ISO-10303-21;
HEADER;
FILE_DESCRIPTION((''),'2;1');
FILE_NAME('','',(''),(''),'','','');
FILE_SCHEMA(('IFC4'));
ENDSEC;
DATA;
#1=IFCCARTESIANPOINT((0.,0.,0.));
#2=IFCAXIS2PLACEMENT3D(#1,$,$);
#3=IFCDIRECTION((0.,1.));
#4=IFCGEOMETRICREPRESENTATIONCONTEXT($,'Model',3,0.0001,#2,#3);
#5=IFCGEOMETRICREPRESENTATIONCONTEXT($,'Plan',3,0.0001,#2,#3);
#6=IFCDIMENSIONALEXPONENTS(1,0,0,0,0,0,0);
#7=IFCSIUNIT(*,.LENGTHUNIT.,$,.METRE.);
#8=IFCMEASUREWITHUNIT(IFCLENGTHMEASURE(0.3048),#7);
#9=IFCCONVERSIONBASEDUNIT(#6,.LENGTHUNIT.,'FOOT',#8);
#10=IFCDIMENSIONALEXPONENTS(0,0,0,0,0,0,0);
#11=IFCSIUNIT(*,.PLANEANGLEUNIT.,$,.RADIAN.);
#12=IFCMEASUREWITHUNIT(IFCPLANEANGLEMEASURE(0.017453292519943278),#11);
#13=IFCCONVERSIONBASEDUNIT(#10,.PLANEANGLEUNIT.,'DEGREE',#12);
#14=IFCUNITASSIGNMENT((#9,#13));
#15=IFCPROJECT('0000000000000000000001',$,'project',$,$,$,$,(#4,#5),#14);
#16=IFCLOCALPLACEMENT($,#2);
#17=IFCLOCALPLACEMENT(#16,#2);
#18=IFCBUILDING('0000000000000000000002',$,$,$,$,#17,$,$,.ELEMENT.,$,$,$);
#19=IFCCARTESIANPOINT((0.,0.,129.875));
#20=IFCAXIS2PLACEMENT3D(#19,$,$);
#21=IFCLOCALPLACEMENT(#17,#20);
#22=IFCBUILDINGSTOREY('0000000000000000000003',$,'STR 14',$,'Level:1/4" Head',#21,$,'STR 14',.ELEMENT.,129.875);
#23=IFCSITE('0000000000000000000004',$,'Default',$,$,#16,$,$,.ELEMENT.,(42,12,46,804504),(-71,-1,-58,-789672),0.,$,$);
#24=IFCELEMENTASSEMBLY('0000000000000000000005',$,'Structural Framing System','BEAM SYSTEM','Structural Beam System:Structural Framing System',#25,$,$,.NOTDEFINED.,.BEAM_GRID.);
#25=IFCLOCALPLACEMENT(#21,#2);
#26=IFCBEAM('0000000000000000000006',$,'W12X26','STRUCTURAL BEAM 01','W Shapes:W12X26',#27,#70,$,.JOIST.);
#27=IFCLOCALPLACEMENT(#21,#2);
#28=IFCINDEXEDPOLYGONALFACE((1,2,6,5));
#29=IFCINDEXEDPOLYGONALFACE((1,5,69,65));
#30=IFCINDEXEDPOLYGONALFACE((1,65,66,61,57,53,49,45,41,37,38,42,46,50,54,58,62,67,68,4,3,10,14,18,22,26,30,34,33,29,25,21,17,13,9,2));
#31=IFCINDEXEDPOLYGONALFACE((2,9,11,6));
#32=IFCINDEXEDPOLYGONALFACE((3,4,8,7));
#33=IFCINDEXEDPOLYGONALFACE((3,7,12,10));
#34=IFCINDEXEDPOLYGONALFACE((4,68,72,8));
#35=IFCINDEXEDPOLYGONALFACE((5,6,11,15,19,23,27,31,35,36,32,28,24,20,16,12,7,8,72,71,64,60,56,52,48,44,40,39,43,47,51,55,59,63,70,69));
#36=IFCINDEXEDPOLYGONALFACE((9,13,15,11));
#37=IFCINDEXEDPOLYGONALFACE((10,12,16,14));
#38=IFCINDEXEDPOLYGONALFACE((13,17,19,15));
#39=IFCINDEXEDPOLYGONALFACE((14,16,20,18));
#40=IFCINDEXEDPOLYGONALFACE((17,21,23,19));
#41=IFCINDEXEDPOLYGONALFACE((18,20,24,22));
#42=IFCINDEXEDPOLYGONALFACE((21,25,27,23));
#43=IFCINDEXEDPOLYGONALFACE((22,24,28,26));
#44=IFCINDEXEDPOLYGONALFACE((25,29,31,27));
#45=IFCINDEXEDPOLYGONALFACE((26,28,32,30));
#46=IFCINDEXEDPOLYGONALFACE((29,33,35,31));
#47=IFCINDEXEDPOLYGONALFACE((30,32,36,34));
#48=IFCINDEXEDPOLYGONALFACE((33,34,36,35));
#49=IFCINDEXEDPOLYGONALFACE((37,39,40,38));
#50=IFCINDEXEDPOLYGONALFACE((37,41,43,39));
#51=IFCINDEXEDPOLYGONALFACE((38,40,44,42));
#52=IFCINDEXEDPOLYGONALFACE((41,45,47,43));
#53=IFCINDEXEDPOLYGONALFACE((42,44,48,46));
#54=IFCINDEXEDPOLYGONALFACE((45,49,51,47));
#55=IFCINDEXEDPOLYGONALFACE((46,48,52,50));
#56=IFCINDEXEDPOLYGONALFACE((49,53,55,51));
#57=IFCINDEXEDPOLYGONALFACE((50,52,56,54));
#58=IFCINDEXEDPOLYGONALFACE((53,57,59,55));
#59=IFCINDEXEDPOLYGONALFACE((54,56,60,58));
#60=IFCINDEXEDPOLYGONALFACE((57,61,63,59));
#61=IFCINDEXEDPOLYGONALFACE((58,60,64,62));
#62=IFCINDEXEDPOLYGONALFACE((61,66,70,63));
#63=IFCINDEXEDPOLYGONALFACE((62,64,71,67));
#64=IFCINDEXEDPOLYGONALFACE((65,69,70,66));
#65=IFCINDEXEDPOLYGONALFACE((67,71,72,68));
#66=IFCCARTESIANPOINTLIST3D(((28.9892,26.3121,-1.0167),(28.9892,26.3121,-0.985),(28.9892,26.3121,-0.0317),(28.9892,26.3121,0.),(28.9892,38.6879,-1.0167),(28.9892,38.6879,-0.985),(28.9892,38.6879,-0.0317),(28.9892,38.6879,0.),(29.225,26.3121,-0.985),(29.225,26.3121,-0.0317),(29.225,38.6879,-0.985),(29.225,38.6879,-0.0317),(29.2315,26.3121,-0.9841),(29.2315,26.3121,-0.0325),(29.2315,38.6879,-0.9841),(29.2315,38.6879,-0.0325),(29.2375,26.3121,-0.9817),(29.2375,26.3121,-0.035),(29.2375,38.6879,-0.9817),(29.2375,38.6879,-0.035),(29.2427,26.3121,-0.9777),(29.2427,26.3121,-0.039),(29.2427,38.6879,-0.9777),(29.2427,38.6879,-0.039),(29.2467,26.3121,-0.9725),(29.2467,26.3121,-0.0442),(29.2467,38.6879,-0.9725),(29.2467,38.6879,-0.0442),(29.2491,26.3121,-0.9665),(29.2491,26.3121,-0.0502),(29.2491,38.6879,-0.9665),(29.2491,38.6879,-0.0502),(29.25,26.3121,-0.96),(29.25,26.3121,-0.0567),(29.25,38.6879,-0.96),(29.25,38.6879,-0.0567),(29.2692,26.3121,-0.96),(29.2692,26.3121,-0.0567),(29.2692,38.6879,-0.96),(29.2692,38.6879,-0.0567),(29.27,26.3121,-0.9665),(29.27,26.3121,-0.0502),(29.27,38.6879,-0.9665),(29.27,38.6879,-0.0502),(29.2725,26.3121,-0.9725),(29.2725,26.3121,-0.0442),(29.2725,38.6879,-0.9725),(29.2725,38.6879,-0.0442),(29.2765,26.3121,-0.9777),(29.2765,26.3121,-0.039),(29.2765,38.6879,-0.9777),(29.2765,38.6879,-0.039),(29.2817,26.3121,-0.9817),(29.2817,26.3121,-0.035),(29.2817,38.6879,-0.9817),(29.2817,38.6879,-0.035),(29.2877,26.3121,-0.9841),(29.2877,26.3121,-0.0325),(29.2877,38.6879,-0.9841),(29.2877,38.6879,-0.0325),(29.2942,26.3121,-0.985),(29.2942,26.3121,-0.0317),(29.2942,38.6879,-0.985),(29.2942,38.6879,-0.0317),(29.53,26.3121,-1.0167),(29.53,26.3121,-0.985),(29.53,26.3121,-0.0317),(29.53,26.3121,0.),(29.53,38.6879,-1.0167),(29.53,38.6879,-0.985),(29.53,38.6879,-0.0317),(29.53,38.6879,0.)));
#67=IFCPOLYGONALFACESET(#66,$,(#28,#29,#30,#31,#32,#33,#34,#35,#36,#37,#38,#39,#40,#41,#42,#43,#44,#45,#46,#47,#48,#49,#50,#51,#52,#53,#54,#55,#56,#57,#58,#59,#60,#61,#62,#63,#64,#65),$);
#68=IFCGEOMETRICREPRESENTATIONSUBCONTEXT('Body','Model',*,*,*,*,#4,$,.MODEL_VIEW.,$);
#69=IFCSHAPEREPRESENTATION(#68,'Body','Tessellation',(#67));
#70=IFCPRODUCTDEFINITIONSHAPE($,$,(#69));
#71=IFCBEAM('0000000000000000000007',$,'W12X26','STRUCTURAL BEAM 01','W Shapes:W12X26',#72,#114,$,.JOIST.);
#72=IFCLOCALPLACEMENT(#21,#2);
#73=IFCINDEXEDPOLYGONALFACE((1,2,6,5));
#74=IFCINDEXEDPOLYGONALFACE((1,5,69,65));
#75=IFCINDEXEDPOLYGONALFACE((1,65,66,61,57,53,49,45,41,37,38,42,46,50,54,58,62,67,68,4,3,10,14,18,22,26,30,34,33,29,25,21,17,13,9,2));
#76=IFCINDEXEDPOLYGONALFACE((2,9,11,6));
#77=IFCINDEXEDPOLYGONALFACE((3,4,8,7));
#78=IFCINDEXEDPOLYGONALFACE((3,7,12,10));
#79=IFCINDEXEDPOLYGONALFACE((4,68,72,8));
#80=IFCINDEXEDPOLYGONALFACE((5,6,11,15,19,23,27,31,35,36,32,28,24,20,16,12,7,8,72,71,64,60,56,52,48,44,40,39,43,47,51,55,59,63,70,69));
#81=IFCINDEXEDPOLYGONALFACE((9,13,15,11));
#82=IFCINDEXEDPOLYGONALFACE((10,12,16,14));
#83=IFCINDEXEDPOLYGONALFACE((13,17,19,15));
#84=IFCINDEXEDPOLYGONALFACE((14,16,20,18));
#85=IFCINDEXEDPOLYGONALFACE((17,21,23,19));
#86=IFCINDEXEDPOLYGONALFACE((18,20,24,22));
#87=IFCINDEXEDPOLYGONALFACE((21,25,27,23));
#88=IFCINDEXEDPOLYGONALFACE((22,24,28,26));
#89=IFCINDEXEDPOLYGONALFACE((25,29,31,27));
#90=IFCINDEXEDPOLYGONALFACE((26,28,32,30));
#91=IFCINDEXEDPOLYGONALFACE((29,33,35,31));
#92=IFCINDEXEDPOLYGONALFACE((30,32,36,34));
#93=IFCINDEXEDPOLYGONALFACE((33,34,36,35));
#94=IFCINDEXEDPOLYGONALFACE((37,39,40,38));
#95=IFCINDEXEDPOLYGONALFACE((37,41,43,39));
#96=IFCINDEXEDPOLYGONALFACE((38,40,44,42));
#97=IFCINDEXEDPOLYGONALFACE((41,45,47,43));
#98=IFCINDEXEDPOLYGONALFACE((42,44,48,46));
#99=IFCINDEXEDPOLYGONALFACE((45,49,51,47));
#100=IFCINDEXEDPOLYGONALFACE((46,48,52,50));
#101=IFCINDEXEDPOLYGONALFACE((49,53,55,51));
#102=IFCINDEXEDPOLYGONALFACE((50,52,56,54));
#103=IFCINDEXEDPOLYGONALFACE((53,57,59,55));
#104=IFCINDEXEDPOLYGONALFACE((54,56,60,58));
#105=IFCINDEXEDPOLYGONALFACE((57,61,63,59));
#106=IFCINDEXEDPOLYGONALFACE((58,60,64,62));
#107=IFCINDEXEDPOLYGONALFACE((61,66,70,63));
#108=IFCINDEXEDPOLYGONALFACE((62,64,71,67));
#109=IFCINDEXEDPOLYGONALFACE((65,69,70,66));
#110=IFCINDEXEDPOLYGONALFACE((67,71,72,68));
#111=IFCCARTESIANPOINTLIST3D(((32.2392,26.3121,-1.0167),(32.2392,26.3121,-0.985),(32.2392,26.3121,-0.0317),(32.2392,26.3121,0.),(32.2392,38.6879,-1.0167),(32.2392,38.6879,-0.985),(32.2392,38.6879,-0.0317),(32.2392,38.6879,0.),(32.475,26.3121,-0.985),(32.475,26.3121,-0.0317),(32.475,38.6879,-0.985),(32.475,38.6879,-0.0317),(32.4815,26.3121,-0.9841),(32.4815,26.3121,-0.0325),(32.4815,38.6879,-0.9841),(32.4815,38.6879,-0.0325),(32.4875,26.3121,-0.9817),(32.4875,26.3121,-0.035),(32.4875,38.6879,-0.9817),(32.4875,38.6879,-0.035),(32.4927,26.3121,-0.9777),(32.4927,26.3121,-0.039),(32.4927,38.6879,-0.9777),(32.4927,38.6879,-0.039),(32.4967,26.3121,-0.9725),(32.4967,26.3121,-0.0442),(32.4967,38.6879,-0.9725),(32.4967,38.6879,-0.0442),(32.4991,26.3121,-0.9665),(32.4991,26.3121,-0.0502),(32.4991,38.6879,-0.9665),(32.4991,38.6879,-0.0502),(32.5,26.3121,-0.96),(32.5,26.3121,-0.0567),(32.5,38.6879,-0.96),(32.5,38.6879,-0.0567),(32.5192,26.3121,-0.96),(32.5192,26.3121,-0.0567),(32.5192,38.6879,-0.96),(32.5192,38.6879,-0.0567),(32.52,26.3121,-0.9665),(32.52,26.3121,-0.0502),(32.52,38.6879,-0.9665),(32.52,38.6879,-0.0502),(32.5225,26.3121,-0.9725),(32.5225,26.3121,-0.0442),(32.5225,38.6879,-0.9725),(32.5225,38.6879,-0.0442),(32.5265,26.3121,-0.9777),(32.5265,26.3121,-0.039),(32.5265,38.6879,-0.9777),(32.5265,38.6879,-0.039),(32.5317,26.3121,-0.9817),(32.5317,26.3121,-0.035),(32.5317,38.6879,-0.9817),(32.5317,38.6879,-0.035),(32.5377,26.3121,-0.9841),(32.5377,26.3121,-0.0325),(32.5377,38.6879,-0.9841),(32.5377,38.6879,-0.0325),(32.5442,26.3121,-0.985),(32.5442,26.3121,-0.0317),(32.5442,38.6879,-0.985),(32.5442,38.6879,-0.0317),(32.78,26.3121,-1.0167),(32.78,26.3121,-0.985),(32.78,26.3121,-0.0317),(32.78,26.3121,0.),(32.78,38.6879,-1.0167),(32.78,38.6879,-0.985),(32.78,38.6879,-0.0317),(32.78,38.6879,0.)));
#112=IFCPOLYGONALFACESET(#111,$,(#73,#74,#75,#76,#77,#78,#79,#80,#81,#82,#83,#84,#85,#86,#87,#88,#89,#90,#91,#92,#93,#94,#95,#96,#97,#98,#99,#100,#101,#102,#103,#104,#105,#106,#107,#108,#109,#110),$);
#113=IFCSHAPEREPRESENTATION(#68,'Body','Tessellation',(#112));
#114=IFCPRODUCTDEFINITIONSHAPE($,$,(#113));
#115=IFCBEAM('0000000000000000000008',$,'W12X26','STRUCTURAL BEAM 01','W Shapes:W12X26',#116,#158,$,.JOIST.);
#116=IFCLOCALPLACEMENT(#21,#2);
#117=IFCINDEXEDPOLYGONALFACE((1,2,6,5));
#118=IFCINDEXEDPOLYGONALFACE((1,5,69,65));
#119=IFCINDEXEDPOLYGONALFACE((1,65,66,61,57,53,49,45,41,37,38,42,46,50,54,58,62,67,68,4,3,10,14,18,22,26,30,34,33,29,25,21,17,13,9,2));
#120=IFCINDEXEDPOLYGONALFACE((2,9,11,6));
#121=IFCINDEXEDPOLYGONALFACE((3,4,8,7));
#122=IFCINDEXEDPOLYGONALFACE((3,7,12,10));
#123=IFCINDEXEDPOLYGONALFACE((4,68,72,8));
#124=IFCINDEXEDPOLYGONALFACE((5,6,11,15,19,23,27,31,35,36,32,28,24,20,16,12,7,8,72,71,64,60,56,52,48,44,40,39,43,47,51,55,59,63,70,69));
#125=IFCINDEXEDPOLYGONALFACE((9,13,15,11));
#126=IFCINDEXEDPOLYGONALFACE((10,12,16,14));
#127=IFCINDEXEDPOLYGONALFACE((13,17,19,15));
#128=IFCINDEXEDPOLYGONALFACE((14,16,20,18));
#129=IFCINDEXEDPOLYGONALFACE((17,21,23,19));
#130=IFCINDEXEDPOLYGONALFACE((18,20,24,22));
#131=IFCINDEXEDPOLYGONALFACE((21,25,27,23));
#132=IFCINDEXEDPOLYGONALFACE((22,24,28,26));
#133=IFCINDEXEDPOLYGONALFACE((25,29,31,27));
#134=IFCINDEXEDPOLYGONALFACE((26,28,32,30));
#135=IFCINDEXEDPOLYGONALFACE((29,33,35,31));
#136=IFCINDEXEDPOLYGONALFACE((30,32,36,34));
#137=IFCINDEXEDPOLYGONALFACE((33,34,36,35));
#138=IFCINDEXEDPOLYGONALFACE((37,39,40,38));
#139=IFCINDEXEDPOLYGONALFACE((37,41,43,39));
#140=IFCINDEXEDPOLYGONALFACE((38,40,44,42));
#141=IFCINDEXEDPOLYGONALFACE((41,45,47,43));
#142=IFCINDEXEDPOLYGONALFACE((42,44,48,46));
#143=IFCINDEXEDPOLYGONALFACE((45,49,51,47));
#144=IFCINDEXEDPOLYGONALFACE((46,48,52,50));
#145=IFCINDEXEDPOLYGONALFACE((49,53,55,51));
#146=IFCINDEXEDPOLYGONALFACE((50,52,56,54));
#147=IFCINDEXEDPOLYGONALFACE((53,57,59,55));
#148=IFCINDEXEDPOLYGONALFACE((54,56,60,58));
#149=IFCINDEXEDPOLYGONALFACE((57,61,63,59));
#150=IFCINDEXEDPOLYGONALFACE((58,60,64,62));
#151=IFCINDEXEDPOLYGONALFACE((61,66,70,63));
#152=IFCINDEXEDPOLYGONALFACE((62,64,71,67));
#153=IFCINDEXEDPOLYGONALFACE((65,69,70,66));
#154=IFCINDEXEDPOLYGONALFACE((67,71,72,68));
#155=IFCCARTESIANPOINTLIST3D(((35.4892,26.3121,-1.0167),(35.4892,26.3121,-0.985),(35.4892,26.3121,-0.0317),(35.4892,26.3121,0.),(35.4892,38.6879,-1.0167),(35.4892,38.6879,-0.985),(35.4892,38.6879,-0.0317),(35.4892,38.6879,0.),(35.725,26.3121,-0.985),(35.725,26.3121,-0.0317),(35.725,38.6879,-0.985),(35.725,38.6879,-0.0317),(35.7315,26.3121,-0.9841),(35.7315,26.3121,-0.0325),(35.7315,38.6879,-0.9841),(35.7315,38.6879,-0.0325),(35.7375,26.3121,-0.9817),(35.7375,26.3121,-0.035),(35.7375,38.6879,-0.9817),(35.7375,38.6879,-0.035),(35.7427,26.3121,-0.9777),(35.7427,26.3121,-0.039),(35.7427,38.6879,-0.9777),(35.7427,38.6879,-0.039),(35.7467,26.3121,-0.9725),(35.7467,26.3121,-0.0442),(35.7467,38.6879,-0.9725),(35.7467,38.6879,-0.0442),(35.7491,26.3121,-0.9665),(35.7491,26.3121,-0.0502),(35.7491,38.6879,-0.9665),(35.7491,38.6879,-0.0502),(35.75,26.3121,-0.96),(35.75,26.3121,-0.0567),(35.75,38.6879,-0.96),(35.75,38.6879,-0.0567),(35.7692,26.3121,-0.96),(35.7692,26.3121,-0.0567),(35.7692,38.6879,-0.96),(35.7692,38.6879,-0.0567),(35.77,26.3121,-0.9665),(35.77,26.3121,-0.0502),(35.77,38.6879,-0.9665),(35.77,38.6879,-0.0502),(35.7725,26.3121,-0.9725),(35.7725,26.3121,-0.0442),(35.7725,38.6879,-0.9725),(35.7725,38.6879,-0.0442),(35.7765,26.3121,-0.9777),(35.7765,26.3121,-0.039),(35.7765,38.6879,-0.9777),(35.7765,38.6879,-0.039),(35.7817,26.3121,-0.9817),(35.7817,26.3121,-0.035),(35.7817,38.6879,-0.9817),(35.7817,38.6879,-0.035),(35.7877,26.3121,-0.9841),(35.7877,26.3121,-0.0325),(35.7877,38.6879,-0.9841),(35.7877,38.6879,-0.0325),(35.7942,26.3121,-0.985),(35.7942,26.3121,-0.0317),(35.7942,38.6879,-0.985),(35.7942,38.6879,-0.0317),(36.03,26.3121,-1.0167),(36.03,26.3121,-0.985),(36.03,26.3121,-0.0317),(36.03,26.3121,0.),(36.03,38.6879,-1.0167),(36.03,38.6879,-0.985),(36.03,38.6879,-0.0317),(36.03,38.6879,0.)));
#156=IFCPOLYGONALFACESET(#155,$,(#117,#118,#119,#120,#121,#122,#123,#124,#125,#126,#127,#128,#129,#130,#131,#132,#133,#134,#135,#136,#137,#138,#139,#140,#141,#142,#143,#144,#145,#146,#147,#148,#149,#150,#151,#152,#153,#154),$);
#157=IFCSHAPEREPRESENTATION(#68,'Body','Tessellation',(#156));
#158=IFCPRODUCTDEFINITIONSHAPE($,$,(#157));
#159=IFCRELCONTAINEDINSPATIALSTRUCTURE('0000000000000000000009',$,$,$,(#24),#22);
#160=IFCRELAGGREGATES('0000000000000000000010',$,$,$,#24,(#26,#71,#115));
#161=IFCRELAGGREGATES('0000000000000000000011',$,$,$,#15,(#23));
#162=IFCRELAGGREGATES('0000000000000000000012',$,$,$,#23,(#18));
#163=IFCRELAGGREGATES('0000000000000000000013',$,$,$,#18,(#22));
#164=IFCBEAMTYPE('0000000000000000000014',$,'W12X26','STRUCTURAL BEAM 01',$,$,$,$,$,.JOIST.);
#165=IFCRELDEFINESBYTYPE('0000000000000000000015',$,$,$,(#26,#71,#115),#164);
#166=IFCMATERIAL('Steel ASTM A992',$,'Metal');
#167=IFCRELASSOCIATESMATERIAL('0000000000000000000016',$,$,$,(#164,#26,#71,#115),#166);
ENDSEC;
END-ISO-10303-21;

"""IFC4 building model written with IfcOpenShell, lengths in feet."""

from ifc_helpers import new_model, entity, si_unit, converted_unit, direction, frame, origin, place, context, subcontext, project, spatial, line, arc, indexed_curve, outline, extrude, source, transform, mapped, material, type_object, type_shapes, element, aggregate, save


model = new_model("IFC4")

# Units and contexts
model_context = context("Model", 3, precision=0.0001, world=origin(), true_north=direction((0.0, 1.0)))
plan_context = context("Plan", 3, precision=0.0001, world=origin(), true_north=direction((0.0, 1.0)))
body_context = subcontext(model_context, "Body", "Model", "MODEL_VIEW")
ifc_project = project(units=[converted_unit("LENGTHUNIT", "FOOT", entity("IfcLengthMeasure", 0.3048), si_unit("LENGTHUNIT", "METRE"), dimensions=[1, 0, 0, 0, 0, 0, 0]), converted_unit("PLANEANGLEUNIT", "DEGREE", entity("IfcPlaneAngleMeasure", 0.017453292519943278), si_unit("PLANEANGLEUNIT", "RADIAN"), dimensions=[0, 0, 0, 0, 0, 0, 0])], contexts=[model_context, plan_context])

# Site, building, storey
site_placement = place(None, origin())
site = spatial("IfcSite", under=ifc_project, at=site_placement, Name="Default", CompositionType="ELEMENT", RefLatitude=(42, 12, 46, 804504), RefLongitude=(-71, -1, -58, -789672), RefElevation=0.0)
building_placement = place(site_placement, origin())
building = spatial("IfcBuilding", under=site, at=building_placement, CompositionType="ELEMENT")
storey_placement = place(building_placement, frame((0.0, 0.0, 129.875)))
storey = spatial("IfcBuildingStorey", under=building, at=storey_placement, Name="STR 14", ObjectType="Level:1/4\" Head", LongName="STR 14", CompositionType="ELEMENT", Elevation=129.875)

# Shared definitions
ifc_material = material(Name="Steel ASTM A992", Category="Metal")

# Element assembly, beams
beam_type_1 = type_object("IfcBeamType", Name="W12X26", Description="STRUCTURAL BEAM 01", PredefinedType="JOIST", material=ifc_material)
shared_shape_1 = source(origin(), body_context, "Body", "SweptSolid", [
    extrude(outline(indexed_curve([(-0.2704, -0.4767), (-0.2704, -0.5083), (0.2704, -0.5083), (0.2704, -0.4767), (0.0346, -0.4767), (0.0169, -0.4693), (0.0096, -0.4517), (0.0096, 0.4517), (0.0169, 0.4693), (0.0346, 0.4767), (0.2704, 0.4767), (0.2704, 0.5083), (-0.2704, 0.5083), (-0.2704, 0.4767), (-0.0346, 0.4767), (-0.0169, 0.4693), (-0.0096, 0.4517), (-0.0096, -0.4517), (-0.0169, -0.4693), (-0.0346, -0.4767)], segments=[line(1, 2, 3, 4, 5), arc(5, 6, 7), line(7, 8), arc(8, 9, 10), line(10, 11, 12, 13, 14, 15), arc(15, 16, 17), line(17, 18), arc(18, 19, 20), line(20, 1)], self_intersect=False)), frame((-6.1879, 0.0, 0.0), z_axis=(-1.0, 0.0, 0.0), x_axis=(0.0, -1.0, 0.0)), (0.0, 0.0, -1.0), 12.3758),
])
type_shapes(beam_type_1, [shared_shape_1])
assembly_1_placement = place(storey_placement, origin())
assembly_1 = element("IfcElementAssembly", 1, at=assembly_1_placement, inside=storey, Name="Structural Framing System", Description="BEAM SYSTEM", ObjectType="Structural Beam System:Structural Framing System", AssemblyPlace="NOTDEFINED", PredefinedType="BEAM_GRID")
beam_1_placement = place(assembly_1_placement, frame((29.2596, 32.5, -0.5083), z_axis=(0.0, 0.0, 1.0), x_axis=(0.0, 1.0, 0.0)))
beam_1 = element("IfcBeam", 2, at=beam_1_placement, type_object=beam_type_1, material=ifc_material, Name="W12X26", Description="STRUCTURAL BEAM 01", ObjectType="W Shapes:W12X26", PredefinedType="JOIST", context=body_context, shape_type="MappedRepresentation", body=[
    mapped(shared_shape_1, transform((0.0, 0.0, 0.0), scale=1.0)),
])
beam_2_placement = place(assembly_1_placement, frame((32.5096, 32.5, -0.5083), z_axis=(0.0, 0.0, 1.0), x_axis=(0.0, 1.0, 0.0)))
beam_2 = element("IfcBeam", 3, at=beam_2_placement, type_object=beam_type_1, material=ifc_material, Name="W12X26", Description="STRUCTURAL BEAM 01", ObjectType="W Shapes:W12X26", PredefinedType="JOIST", context=body_context, shape_type="MappedRepresentation", body=[
    mapped(shared_shape_1, transform((0.0, 0.0, 0.0), scale=1.0)),
])
beam_3_placement = place(assembly_1_placement, frame((35.7596, 32.5, -0.5083), z_axis=(0.0, 0.0, 1.0), x_axis=(0.0, 1.0, 0.0)))
beam_3 = element("IfcBeam", 4, at=beam_3_placement, type_object=beam_type_1, material=ifc_material, Name="W12X26", Description="STRUCTURAL BEAM 01", ObjectType="W Shapes:W12X26", PredefinedType="JOIST", context=body_context, shape_type="MappedRepresentation", body=[
    mapped(shared_shape_1, transform((0.0, 0.0, 0.0), scale=1.0)),
])
aggregate(assembly_1, [beam_1, beam_2, beam_3])

save(model, "model.ifc")
